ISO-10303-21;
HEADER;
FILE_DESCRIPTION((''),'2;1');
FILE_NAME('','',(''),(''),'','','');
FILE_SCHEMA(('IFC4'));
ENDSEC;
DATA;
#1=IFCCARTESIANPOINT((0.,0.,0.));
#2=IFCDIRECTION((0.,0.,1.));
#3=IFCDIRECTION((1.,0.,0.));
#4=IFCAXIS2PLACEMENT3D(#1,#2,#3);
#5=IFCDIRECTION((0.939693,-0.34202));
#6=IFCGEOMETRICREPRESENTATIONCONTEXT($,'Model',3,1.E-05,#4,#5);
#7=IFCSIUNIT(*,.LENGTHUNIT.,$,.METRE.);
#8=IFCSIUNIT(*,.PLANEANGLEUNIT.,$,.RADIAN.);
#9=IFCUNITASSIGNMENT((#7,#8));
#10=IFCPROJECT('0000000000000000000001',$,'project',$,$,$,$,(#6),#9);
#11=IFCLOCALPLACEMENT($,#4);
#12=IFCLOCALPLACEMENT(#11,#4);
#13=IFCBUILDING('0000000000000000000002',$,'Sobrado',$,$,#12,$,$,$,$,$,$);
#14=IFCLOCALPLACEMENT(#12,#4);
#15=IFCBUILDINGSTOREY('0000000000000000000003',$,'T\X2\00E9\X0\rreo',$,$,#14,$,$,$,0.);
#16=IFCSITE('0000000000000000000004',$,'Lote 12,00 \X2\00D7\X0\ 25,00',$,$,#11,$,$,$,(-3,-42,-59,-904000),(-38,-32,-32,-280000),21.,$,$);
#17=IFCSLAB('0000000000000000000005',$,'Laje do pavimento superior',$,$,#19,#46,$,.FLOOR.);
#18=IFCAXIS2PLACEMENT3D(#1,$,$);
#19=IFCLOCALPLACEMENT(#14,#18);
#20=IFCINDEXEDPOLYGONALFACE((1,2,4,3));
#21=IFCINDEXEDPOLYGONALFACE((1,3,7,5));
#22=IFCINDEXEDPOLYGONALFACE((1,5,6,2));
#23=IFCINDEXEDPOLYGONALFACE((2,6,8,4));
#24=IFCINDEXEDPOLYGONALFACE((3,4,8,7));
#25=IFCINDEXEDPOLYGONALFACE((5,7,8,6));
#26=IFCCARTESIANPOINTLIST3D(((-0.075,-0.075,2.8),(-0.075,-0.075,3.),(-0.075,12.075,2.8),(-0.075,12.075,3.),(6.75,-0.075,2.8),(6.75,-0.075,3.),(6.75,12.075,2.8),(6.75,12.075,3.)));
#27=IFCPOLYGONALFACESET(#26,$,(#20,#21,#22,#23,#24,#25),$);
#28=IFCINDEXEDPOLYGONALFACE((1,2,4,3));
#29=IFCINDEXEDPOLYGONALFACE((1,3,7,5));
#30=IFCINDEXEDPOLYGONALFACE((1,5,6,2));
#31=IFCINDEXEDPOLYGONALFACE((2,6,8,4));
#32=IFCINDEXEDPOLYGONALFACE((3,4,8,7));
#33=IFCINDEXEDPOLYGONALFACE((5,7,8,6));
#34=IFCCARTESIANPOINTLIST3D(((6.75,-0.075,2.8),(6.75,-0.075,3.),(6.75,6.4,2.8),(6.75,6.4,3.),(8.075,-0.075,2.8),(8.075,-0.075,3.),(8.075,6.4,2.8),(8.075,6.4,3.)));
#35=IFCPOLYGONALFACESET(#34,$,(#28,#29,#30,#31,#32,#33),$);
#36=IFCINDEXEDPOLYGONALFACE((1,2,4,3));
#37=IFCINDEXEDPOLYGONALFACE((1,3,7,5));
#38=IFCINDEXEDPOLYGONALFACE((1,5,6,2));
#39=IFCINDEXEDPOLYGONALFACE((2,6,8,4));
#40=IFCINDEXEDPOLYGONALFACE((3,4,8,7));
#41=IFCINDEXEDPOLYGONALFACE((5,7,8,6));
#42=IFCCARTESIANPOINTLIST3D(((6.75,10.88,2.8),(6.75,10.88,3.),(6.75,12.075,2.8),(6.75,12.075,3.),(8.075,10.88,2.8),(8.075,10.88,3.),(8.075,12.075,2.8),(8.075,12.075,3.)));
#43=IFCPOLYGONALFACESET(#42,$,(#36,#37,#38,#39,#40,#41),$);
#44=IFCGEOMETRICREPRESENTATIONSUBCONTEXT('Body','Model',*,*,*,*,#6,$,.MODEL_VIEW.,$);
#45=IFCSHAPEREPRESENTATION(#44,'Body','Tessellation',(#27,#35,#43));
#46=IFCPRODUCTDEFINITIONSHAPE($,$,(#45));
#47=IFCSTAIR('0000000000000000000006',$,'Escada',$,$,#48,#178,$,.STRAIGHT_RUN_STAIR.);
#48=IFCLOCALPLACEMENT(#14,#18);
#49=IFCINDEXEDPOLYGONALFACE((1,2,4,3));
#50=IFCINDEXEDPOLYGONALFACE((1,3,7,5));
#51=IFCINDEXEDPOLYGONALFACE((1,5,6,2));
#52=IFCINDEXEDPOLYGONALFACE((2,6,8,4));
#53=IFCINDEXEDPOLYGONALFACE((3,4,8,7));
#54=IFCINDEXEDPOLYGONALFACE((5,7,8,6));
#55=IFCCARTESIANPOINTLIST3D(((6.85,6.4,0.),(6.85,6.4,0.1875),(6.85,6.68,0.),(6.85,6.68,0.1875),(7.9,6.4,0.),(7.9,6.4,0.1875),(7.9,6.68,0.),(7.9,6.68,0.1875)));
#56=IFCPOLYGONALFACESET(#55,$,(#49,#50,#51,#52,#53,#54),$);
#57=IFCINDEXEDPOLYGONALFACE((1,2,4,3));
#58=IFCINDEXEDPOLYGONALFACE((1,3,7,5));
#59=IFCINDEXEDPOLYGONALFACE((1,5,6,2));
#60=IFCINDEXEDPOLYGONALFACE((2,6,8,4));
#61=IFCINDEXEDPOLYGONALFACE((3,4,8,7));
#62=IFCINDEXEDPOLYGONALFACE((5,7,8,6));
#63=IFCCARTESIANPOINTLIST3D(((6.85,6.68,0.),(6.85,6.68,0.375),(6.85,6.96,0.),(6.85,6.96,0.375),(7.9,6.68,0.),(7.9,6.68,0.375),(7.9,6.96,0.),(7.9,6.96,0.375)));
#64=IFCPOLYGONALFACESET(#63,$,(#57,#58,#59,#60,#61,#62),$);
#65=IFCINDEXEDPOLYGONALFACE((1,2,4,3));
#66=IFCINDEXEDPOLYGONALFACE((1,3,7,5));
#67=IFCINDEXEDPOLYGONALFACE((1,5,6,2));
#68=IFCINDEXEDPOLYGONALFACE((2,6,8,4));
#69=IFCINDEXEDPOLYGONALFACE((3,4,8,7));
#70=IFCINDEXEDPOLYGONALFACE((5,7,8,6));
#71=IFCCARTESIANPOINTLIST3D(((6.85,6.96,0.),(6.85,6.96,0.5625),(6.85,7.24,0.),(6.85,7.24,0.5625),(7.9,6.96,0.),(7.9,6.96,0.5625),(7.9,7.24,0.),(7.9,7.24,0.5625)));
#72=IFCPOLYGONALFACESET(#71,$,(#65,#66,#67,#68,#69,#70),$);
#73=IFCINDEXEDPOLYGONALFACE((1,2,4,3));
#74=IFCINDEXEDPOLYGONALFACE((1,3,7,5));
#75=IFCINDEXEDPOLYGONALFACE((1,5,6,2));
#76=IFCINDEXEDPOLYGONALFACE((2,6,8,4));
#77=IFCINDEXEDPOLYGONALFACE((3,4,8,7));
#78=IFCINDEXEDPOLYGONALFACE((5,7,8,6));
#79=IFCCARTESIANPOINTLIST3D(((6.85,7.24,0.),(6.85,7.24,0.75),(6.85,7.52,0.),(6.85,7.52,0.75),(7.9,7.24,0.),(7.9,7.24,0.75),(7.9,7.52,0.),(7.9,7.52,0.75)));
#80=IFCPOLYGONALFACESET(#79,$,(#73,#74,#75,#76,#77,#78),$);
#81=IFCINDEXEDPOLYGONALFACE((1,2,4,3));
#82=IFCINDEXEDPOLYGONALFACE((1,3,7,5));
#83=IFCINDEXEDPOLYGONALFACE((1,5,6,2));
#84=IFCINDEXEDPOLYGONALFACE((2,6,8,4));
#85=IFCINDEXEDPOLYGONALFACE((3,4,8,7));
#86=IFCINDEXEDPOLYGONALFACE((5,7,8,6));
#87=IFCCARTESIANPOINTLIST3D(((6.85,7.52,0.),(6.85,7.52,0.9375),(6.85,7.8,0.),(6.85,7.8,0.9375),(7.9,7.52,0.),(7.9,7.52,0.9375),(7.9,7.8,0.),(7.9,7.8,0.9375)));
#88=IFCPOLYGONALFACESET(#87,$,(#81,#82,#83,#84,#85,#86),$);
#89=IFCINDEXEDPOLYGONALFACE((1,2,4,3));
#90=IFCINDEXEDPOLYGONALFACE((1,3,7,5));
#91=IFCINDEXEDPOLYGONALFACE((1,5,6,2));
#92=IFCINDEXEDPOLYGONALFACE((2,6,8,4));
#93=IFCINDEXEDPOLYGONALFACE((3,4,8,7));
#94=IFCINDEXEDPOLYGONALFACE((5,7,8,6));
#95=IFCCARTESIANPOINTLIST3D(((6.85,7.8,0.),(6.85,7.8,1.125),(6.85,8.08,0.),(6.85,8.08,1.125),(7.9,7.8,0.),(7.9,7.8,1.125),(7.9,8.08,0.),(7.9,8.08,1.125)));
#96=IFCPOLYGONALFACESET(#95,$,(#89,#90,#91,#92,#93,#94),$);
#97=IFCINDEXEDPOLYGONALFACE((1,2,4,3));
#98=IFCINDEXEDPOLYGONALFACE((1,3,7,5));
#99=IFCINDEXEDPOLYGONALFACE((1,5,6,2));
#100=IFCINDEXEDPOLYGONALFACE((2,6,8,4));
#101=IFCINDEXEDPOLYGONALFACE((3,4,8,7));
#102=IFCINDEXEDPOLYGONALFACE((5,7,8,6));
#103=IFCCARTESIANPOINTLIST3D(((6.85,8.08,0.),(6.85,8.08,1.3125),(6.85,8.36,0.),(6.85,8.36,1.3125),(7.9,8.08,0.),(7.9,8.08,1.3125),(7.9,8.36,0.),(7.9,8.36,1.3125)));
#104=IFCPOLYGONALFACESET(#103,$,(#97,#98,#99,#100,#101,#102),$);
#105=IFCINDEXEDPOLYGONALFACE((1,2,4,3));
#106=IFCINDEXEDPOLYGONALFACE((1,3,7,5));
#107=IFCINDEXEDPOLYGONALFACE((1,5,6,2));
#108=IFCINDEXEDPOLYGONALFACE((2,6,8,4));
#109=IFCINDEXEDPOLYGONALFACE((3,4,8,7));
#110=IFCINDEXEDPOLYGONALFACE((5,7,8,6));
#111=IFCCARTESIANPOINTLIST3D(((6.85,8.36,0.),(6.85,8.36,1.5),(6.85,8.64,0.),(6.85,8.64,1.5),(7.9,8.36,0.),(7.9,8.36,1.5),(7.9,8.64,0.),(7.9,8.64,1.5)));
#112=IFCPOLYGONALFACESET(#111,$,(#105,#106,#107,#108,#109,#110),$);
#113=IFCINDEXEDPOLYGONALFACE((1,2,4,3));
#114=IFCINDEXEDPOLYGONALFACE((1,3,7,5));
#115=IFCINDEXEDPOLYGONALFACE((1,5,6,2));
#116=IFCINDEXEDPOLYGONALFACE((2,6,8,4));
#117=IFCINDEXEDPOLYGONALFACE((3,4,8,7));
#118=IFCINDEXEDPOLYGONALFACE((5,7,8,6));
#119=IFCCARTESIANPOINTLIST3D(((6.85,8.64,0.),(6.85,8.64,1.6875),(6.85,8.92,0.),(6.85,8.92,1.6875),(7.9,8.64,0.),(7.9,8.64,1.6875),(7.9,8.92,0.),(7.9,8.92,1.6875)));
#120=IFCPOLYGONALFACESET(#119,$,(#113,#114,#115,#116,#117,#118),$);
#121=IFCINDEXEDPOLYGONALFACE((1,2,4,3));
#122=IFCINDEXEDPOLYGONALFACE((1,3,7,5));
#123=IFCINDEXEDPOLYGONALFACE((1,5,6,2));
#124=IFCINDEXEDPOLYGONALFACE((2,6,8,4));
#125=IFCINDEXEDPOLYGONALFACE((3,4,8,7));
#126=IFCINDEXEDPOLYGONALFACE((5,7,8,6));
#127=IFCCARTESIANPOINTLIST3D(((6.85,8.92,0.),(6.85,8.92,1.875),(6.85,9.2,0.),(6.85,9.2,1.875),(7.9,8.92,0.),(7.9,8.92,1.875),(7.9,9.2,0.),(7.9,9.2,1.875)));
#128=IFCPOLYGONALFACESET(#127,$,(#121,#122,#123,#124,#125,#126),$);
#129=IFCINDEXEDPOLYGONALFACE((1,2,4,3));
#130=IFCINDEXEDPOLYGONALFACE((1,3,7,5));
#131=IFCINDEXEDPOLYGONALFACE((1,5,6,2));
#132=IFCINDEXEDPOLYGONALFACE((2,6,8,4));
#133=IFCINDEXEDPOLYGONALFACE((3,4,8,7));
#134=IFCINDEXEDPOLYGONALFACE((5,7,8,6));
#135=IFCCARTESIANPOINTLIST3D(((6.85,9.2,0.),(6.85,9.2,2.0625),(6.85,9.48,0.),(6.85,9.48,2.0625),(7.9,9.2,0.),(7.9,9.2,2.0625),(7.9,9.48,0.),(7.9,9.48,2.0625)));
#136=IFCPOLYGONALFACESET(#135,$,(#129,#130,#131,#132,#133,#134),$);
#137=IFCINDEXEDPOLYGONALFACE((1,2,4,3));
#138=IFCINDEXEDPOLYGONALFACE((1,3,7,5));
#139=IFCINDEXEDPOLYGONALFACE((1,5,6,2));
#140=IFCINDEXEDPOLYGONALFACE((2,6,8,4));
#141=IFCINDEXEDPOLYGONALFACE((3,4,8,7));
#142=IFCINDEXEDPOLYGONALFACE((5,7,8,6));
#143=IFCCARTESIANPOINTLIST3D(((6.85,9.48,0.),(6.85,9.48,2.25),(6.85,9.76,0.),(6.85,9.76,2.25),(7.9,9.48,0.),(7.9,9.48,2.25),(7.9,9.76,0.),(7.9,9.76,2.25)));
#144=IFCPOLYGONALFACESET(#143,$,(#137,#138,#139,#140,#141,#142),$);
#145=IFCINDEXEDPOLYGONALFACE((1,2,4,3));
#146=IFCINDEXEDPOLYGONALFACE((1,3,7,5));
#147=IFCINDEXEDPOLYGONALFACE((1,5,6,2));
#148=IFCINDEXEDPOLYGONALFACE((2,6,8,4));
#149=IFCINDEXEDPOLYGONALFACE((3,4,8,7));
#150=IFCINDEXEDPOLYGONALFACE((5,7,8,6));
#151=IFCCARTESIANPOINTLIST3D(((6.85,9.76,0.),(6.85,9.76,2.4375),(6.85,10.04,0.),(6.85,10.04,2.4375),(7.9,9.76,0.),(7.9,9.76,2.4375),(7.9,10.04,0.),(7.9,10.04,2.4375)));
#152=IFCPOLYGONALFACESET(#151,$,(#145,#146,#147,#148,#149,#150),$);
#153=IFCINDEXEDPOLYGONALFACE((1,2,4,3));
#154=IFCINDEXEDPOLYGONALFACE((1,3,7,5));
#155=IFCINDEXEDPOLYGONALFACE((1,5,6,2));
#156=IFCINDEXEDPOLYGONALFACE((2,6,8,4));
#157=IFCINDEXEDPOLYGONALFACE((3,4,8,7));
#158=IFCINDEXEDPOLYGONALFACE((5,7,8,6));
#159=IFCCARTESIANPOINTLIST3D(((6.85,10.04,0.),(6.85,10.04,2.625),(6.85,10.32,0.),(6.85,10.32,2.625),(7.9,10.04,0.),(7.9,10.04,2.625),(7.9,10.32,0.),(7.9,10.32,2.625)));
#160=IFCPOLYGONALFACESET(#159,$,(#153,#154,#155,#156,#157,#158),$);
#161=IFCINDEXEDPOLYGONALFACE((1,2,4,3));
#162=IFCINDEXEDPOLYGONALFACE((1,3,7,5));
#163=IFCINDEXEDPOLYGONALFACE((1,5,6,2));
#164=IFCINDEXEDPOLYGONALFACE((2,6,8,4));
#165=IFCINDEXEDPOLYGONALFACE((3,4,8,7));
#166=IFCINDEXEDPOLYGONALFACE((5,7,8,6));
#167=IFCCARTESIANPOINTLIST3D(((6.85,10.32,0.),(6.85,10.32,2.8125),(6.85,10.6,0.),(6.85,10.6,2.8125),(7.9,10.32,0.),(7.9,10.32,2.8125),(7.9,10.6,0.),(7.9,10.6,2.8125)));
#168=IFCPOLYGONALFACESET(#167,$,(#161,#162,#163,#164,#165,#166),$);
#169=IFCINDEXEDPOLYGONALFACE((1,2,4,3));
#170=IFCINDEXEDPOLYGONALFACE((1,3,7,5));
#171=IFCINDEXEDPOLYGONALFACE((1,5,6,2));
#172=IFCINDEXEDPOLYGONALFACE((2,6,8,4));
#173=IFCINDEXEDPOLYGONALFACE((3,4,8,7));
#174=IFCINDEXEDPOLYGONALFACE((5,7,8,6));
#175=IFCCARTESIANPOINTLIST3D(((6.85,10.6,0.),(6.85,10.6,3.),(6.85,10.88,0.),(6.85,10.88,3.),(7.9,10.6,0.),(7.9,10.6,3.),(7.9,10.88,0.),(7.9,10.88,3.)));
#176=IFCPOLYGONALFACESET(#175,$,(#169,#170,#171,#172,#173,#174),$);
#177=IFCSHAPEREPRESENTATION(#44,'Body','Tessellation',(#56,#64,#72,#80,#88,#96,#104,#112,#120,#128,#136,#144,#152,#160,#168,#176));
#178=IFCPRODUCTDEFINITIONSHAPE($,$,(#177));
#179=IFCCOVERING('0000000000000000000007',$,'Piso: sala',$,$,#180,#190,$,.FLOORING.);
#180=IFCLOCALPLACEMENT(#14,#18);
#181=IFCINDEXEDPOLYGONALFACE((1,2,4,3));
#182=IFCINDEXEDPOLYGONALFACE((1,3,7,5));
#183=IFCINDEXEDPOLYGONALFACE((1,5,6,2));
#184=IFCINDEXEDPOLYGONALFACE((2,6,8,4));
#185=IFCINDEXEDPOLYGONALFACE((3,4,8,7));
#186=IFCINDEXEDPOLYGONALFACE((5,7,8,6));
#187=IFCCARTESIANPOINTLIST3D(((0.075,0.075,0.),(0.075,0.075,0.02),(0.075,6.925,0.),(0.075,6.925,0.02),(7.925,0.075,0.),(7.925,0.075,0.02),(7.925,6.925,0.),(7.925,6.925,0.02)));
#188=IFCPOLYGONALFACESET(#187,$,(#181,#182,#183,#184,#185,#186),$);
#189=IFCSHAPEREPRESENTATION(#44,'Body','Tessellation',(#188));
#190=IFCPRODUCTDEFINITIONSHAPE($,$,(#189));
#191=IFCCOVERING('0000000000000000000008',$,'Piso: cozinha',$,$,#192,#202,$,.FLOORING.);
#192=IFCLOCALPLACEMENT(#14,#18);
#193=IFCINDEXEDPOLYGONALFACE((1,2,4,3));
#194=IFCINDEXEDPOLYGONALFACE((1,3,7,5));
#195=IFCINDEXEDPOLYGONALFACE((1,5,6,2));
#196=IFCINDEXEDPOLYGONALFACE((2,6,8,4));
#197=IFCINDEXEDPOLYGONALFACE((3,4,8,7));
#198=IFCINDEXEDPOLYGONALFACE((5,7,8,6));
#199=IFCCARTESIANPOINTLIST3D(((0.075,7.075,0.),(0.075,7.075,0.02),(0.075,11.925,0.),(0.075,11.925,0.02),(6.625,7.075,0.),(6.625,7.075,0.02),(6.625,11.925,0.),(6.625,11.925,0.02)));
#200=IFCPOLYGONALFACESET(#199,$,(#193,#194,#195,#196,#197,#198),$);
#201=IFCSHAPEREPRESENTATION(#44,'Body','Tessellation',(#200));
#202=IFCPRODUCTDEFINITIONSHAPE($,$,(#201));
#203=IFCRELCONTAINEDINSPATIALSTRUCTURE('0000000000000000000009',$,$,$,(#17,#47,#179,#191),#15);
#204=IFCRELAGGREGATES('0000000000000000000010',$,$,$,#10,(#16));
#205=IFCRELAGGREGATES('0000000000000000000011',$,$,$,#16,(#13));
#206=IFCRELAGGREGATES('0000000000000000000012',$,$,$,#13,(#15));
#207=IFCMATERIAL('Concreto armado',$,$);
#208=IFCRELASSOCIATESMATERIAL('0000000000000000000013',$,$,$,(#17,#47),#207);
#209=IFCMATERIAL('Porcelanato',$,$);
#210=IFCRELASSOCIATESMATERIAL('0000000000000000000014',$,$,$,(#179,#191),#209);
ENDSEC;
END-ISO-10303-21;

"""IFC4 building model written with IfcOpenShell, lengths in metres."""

from ifc_helpers import new_model, si_unit, direction, frame, origin_with_axes, place, context, subcontext, project, spatial, line, indexed_curve, outline, extrude, material, element, save


model = new_model("IFC4")

# Units and contexts
model_context = context("Model", 3, precision=1e-05, world=origin_with_axes(), true_north=direction((0.939693, -0.34202)))
body_context = subcontext(model_context, "Body", "Model", "MODEL_VIEW")
ifc_project = project(units=[si_unit("LENGTHUNIT", "METRE"), si_unit("PLANEANGLEUNIT", "RADIAN")], contexts=[model_context])

# Site, building, storey
site_placement = place(None, origin_with_axes())
site = spatial("IfcSite", under=ifc_project, at=site_placement, Name="Lote 12,00 × 25,00", RefLatitude=(-3, -42, -59, -904000), RefLongitude=(-38, -32, -32, -280000), RefElevation=21.0)
building_placement = place(site_placement, origin_with_axes())
building = spatial("IfcBuilding", under=site, at=building_placement, Name="Sobrado")
storey_placement = place(building_placement, origin_with_axes())
storey = spatial("IfcBuildingStorey", under=building, at=storey_placement, Name="Térreo", Elevation=0.0)

# Slab
ifc_material_1 = material(Name="Concreto armado")
slab_placement = place(storey_placement, origin_with_axes())
element("IfcSlab", 1, at=slab_placement, inside=storey, material=ifc_material_1, Name="Laje do pavimento superior", PredefinedType="FLOOR", context=body_context, shape_type="SweptSolid", body=[
    extrude(outline(indexed_curve([(-0.075, -0.075), (6.75, -0.075), (6.75, 12.075), (-0.075, 12.075)], segments=[line(1, 2, 3, 4, 1)])), frame((0.0, 0.0, 2.8), z_axis=(0.0, 0.0, 1.0), x_axis=(1.0, 0.0, 0.0)), (0.0, 0.0, 1.0), 0.2),
    extrude(outline(indexed_curve([(6.75, -0.075), (8.075, -0.075), (8.075, 6.4), (6.75, 6.4)], segments=[line(1, 2, 3, 4, 1)])), frame((0.0, 0.0, 2.8), z_axis=(0.0, 0.0, 1.0), x_axis=(1.0, 0.0, 0.0)), (0.0, 0.0, 1.0), 0.2),
    extrude(outline(indexed_curve([(6.75, 10.88), (8.075, 10.88), (8.075, 12.075), (6.75, 12.075)], segments=[line(1, 2, 3, 4, 1)])), frame((0.0, 0.0, 2.8), z_axis=(0.0, 0.0, 1.0), x_axis=(1.0, 0.0, 0.0)), (0.0, 0.0, 1.0), 0.2),
])

# Stair
stair_placement = place(storey_placement, origin_with_axes())
element("IfcStair", 2, at=stair_placement, inside=storey, material=ifc_material_1, Name="Escada", PredefinedType="STRAIGHT_RUN_STAIR", context=body_context, shape_type="SweptSolid", body=[
    extrude(outline(indexed_curve([(6.85, 6.4), (7.9, 6.4), (7.9, 6.68), (6.85, 6.68)], segments=[line(1, 2, 3, 4, 1)])), origin_with_axes(), (0.0, 0.0, 1.0), 0.1875),
    extrude(outline(indexed_curve([(6.85, 6.68), (7.9, 6.68), (7.9, 6.96), (6.85, 6.96)], segments=[line(1, 2, 3, 4, 1)])), origin_with_axes(), (0.0, 0.0, 1.0), 0.375),
    extrude(outline(indexed_curve([(6.85, 6.96), (7.9, 6.96), (7.9, 7.24), (6.85, 7.24)], segments=[line(1, 2, 3, 4, 1)])), origin_with_axes(), (0.0, 0.0, 1.0), 0.5625),
    extrude(outline(indexed_curve([(6.85, 7.24), (7.9, 7.24), (7.9, 7.52), (6.85, 7.52)], segments=[line(1, 2, 3, 4, 1)])), origin_with_axes(), (0.0, 0.0, 1.0), 0.75),
    extrude(outline(indexed_curve([(6.85, 7.52), (7.9, 7.52), (7.9, 7.8), (6.85, 7.8)], segments=[line(1, 2, 3, 4, 1)])), origin_with_axes(), (0.0, 0.0, 1.0), 0.9375),
    extrude(outline(indexed_curve([(6.85, 7.8), (7.9, 7.8), (7.9, 8.08), (6.85, 8.08)], segments=[line(1, 2, 3, 4, 1)])), origin_with_axes(), (0.0, 0.0, 1.0), 1.125),
    extrude(outline(indexed_curve([(6.85, 8.08), (7.9, 8.08), (7.9, 8.36), (6.85, 8.36)], segments=[line(1, 2, 3, 4, 1)])), origin_with_axes(), (0.0, 0.0, 1.0), 1.3125),
    extrude(outline(indexed_curve([(6.85, 8.36), (7.9, 8.36), (7.9, 8.64), (6.85, 8.64)], segments=[line(1, 2, 3, 4, 1)])), origin_with_axes(), (0.0, 0.0, 1.0), 1.5),
    extrude(outline(indexed_curve([(6.85, 8.64), (7.9, 8.64), (7.9, 8.92), (6.85, 8.92)], segments=[line(1, 2, 3, 4, 1)])), origin_with_axes(), (0.0, 0.0, 1.0), 1.6875),
    extrude(outline(indexed_curve([(6.85, 8.92), (7.9, 8.92), (7.9, 9.2), (6.85, 9.2)], segments=[line(1, 2, 3, 4, 1)])), origin_with_axes(), (0.0, 0.0, 1.0), 1.875),
    extrude(outline(indexed_curve([(6.85, 9.2), (7.9, 9.2), (7.9, 9.48), (6.85, 9.48)], segments=[line(1, 2, 3, 4, 1)])), origin_with_axes(), (0.0, 0.0, 1.0), 2.0625),
    extrude(outline(indexed_curve([(6.85, 9.48), (7.9, 9.48), (7.9, 9.76), (6.85, 9.76)], segments=[line(1, 2, 3, 4, 1)])), origin_with_axes(), (0.0, 0.0, 1.0), 2.25),
    extrude(outline(indexed_curve([(6.85, 9.76), (7.9, 9.76), (7.9, 10.04), (6.85, 10.04)], segments=[line(1, 2, 3, 4, 1)])), origin_with_axes(), (0.0, 0.0, 1.0), 2.4375),
    extrude(outline(indexed_curve([(6.85, 10.04), (7.9, 10.04), (7.9, 10.32), (6.85, 10.32)], segments=[line(1, 2, 3, 4, 1)])), origin_with_axes(), (0.0, 0.0, 1.0), 2.625),
    extrude(outline(indexed_curve([(6.85, 10.32), (7.9, 10.32), (7.9, 10.6), (6.85, 10.6)], segments=[line(1, 2, 3, 4, 1)])), origin_with_axes(), (0.0, 0.0, 1.0), 2.8125),
    extrude(outline(indexed_curve([(6.85, 10.6), (7.9, 10.6), (7.9, 10.88), (6.85, 10.88)], segments=[line(1, 2, 3, 4, 1)])), origin_with_axes(), (0.0, 0.0, 1.0), 3.0),
])

# Coverings
ifc_material_2 = material(Name="Porcelanato")
covering_1_placement = place(storey_placement, origin_with_axes())
element("IfcCovering", 3, at=covering_1_placement, inside=storey, material=ifc_material_2, Name="Piso: sala", PredefinedType="FLOORING", context=body_context, shape_type="SweptSolid", body=[
    extrude(outline(indexed_curve([(0.075, 0.075), (7.925, 0.075), (7.925, 6.925), (0.075, 6.925)], segments=[line(1, 2, 3, 4, 1)])), origin_with_axes(), (0.0, 0.0, 1.0), 0.02),
])
covering_2_placement = place(storey_placement, origin_with_axes())
element("IfcCovering", 4, at=covering_2_placement, inside=storey, material=ifc_material_2, Name="Piso: cozinha", PredefinedType="FLOORING", context=body_context, shape_type="SweptSolid", body=[
    extrude(outline(indexed_curve([(0.075, 7.075), (6.625, 7.075), (6.625, 11.925), (0.075, 11.925)], segments=[line(1, 2, 3, 4, 1)])), origin_with_axes(), (0.0, 0.0, 1.0), 0.02),
])

save(model, "model.ifc")
